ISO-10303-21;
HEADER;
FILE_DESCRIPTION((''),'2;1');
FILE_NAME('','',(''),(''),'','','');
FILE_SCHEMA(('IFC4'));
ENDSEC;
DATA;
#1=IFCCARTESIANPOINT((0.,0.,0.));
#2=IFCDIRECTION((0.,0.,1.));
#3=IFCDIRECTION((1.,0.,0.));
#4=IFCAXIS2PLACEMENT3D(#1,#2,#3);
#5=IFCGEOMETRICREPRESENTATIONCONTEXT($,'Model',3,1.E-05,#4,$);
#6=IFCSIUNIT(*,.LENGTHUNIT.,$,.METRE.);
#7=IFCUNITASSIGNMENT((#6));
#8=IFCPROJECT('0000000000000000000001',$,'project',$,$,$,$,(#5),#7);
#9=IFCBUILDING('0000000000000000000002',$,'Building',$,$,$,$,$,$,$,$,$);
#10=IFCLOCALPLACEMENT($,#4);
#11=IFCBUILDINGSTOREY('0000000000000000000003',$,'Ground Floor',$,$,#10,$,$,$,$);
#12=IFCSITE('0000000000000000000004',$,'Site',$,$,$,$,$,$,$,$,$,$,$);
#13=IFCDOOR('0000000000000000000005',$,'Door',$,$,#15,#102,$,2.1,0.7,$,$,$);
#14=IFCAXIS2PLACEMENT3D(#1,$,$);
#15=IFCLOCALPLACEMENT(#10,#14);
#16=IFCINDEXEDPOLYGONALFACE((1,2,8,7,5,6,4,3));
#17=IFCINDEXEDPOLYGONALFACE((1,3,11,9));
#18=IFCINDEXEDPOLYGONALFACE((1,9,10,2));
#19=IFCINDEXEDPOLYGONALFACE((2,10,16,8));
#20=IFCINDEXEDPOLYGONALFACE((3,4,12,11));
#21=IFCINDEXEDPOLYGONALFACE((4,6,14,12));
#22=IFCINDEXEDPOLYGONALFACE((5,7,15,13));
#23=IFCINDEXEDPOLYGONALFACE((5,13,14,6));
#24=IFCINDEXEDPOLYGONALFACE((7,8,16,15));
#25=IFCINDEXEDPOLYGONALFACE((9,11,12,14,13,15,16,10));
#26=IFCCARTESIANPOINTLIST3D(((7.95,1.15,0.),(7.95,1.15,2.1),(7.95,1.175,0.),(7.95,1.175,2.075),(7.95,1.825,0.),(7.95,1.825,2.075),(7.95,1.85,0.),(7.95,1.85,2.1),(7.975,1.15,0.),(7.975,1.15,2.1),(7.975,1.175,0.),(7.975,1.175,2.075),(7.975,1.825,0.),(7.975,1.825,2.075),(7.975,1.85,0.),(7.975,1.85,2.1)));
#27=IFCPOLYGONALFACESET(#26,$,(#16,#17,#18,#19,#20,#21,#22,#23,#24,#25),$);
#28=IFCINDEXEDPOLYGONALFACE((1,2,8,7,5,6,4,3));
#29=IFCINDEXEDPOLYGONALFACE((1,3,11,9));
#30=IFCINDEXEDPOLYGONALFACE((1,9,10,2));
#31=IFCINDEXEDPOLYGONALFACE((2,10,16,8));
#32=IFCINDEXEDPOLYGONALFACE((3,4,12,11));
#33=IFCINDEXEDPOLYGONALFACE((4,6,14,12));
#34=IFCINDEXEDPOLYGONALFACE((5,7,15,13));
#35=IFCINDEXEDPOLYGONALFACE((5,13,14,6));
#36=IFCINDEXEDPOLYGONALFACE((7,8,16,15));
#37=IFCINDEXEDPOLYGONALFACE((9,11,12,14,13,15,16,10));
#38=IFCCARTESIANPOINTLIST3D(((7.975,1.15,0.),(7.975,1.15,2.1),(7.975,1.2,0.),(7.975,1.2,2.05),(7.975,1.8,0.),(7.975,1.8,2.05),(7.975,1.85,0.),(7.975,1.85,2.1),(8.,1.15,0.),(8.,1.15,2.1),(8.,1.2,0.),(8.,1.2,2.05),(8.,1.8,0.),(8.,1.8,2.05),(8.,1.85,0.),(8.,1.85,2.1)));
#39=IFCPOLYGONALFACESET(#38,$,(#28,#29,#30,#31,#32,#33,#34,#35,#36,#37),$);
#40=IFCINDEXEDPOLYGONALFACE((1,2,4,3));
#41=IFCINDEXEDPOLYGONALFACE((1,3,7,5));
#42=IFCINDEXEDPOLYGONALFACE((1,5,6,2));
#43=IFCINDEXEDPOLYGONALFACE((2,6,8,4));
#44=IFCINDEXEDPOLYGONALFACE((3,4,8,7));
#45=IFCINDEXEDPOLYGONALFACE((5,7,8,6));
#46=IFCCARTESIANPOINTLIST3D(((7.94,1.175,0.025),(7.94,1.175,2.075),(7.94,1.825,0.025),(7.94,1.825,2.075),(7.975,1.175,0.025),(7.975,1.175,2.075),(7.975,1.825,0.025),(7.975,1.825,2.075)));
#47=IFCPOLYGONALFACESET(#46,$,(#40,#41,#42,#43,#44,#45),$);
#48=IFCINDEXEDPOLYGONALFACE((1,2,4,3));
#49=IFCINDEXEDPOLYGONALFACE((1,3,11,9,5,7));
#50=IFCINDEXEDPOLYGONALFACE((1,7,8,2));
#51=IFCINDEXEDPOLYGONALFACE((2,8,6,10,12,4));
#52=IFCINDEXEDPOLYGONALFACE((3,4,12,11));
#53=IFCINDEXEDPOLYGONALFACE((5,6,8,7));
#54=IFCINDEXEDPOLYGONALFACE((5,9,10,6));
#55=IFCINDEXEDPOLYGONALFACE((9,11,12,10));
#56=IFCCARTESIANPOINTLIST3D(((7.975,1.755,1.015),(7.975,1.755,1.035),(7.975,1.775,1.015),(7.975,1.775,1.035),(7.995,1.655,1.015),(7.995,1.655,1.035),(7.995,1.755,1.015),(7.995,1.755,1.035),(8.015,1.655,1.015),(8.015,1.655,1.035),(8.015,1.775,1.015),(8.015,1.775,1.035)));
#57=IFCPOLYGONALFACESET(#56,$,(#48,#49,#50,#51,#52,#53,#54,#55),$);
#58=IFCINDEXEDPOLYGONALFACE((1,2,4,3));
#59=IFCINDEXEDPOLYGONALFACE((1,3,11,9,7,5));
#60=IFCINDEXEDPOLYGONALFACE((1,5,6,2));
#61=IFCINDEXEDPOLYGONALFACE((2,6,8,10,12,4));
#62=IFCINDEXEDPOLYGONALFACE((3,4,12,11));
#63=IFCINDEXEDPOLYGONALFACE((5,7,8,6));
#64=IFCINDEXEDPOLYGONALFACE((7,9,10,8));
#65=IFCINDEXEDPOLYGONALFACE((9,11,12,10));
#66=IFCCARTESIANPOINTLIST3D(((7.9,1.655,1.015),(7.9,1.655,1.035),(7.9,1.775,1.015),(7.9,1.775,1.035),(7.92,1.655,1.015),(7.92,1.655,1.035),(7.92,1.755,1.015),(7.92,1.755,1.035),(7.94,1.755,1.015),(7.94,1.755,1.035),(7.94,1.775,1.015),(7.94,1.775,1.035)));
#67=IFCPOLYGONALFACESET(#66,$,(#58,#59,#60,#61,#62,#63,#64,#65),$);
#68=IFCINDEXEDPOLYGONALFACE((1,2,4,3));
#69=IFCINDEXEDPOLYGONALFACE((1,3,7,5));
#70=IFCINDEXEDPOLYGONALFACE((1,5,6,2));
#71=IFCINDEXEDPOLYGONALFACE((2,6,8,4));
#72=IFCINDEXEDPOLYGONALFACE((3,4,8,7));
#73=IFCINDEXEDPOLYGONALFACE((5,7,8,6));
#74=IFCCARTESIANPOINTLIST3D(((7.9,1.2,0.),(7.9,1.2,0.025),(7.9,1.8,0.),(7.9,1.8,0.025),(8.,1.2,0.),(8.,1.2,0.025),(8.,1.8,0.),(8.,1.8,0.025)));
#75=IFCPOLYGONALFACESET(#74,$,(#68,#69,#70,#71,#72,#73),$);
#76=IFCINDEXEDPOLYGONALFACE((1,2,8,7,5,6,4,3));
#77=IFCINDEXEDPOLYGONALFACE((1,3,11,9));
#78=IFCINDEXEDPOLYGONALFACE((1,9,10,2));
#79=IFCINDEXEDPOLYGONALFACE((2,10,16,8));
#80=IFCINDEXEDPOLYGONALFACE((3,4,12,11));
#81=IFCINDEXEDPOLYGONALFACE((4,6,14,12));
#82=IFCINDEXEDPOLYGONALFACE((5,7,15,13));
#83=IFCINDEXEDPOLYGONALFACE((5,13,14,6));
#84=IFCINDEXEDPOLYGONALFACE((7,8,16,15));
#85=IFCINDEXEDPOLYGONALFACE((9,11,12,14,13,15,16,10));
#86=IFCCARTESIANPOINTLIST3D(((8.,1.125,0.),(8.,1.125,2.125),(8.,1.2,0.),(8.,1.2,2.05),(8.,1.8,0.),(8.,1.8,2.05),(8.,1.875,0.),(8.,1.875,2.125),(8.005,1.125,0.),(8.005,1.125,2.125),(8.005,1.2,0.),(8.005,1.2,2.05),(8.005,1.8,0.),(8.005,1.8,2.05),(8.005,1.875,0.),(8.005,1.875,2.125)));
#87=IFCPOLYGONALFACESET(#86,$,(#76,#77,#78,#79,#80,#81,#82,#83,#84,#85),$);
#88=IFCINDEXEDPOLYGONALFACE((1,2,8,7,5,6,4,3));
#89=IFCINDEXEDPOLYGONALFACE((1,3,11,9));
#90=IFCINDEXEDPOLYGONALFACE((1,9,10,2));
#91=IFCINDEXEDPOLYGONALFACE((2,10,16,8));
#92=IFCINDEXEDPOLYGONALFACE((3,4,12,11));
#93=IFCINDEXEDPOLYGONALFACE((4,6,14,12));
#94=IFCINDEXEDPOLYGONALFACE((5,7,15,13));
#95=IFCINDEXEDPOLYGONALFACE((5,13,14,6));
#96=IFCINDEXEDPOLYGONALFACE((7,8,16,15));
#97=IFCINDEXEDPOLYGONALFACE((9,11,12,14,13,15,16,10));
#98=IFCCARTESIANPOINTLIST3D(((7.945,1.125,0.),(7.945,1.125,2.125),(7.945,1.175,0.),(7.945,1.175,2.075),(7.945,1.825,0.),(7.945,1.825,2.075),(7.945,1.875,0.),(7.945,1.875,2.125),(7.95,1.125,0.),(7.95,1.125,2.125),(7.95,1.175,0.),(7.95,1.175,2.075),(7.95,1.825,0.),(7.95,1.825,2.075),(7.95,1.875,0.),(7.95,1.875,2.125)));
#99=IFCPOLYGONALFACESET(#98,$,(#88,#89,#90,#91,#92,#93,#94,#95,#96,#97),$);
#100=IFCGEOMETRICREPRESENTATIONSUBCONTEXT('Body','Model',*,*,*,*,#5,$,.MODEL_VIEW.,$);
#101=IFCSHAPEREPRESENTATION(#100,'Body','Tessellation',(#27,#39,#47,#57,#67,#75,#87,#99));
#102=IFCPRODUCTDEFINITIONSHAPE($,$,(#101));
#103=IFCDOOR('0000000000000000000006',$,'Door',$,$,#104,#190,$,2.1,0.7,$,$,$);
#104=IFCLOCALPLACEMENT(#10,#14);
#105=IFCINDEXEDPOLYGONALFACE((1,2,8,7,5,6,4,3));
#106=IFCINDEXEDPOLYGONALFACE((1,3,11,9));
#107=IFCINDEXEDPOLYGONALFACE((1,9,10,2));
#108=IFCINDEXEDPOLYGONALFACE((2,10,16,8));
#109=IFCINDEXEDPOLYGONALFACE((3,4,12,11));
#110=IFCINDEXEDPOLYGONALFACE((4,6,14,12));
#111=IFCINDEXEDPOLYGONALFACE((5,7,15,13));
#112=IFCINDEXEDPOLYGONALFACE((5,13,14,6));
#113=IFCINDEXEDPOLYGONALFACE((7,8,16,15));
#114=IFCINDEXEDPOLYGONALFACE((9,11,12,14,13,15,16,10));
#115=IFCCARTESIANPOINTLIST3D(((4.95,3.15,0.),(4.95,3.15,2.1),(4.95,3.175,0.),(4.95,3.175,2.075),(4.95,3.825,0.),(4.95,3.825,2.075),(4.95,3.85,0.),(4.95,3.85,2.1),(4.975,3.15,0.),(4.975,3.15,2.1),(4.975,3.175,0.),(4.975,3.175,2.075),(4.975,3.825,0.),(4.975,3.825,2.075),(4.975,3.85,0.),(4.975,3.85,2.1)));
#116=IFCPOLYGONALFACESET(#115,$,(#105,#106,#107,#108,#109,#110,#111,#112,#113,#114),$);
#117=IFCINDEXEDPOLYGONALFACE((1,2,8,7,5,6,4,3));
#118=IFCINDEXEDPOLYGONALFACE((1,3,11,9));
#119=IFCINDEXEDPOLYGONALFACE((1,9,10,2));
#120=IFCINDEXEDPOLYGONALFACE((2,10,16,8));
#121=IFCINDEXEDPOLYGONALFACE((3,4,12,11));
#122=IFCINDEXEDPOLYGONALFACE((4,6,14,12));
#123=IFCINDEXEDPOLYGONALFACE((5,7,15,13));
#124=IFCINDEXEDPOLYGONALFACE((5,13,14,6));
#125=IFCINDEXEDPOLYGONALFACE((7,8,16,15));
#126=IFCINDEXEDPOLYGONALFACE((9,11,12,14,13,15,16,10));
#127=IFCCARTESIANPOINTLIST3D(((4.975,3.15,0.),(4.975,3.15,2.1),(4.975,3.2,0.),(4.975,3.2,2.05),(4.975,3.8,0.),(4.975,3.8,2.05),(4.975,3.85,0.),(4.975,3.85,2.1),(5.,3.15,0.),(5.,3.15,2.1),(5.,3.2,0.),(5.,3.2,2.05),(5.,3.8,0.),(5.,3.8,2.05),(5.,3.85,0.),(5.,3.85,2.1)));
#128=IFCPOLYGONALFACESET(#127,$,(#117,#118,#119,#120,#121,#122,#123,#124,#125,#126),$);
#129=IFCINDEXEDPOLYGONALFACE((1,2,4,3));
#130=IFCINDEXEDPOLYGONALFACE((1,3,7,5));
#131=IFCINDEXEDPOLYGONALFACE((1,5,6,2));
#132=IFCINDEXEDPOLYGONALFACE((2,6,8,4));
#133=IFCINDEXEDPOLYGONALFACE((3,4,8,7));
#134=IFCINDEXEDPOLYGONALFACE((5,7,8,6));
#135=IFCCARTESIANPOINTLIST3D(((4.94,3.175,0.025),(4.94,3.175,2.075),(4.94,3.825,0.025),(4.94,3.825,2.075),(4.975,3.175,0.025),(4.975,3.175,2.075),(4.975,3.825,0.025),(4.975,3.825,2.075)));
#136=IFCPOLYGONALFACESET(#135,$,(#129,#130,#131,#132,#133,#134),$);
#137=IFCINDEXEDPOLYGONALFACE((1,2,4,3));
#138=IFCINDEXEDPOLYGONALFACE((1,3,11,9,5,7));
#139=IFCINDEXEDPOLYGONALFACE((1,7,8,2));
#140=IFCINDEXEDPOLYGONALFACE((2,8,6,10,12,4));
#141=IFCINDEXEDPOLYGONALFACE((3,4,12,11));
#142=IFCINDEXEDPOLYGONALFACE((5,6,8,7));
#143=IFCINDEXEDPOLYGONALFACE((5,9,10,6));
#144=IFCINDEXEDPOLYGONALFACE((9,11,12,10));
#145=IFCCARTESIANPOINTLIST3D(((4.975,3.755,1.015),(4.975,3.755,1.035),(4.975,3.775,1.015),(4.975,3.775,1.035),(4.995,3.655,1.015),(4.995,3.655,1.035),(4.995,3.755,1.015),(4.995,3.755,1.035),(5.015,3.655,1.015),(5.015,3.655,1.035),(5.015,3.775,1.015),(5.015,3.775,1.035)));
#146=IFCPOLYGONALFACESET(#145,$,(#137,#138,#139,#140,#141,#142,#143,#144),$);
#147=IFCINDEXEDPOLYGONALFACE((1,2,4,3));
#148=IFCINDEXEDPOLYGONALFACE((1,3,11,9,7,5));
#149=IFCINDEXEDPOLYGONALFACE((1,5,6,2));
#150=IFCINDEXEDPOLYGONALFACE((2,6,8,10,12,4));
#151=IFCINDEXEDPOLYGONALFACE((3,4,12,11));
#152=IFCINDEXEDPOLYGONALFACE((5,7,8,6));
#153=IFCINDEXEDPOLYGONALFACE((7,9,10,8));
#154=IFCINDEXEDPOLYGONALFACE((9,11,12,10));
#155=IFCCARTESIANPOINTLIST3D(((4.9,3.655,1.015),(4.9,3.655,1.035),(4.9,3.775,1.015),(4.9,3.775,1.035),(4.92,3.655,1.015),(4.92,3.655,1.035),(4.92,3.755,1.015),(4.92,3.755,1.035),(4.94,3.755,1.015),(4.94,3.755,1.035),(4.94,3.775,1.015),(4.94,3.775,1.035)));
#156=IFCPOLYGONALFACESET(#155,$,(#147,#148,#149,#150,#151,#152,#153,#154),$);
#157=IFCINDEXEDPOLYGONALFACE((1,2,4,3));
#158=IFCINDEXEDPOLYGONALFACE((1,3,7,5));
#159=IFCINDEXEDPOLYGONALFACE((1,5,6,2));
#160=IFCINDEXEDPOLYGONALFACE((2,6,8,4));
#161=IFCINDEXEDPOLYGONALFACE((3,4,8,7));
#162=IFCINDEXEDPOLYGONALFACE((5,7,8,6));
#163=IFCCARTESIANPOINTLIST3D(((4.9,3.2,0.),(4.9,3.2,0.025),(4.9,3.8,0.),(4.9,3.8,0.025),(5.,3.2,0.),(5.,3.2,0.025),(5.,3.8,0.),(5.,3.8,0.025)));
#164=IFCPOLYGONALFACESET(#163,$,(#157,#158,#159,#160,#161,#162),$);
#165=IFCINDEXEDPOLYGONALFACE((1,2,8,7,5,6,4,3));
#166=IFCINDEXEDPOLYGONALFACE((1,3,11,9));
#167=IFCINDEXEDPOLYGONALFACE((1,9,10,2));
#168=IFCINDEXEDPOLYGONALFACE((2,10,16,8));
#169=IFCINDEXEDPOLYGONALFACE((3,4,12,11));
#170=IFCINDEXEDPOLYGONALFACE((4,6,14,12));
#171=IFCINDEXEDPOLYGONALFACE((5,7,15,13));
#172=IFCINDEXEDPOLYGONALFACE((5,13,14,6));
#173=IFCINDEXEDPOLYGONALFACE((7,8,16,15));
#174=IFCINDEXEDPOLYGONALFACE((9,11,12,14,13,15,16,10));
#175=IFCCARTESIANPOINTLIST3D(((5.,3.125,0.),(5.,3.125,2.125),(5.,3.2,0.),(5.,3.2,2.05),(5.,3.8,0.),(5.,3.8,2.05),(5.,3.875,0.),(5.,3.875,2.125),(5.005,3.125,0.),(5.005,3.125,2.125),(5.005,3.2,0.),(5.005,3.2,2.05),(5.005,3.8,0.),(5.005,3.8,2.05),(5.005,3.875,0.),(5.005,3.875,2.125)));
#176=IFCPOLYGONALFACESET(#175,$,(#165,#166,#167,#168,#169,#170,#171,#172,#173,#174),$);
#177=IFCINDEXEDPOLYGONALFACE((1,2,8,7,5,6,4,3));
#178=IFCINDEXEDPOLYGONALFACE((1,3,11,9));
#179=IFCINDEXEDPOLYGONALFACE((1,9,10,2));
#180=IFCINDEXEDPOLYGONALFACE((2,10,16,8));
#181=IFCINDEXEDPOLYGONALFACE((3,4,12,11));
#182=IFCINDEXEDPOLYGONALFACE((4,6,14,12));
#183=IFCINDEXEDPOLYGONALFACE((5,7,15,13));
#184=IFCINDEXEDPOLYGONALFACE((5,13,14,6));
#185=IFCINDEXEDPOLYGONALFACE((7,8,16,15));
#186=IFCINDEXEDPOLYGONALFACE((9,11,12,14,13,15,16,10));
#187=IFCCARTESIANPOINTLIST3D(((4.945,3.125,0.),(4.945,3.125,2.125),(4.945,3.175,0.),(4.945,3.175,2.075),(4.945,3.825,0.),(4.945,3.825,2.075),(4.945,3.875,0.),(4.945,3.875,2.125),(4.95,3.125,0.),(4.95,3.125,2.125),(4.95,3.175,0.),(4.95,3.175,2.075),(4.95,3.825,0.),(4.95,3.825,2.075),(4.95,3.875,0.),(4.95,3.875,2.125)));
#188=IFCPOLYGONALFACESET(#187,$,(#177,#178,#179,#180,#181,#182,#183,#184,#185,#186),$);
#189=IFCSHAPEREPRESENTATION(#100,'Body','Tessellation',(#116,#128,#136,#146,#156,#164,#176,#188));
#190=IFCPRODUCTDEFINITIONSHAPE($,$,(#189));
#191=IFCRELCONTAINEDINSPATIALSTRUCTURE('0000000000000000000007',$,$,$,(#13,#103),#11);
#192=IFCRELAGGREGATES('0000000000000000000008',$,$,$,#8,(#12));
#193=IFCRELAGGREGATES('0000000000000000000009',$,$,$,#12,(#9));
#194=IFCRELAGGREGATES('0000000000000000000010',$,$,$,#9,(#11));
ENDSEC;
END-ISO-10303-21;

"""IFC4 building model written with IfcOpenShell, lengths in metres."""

from ifc_helpers import new_model, si_unit, frame, origin_with_axes, place, context, subcontext, project, spatial, line, indexed_curve, outline, extrude, element, save


model = new_model("IFC4")

# Units and contexts
model_context = context("Model", 3, precision=1e-05, world=origin_with_axes())
body_context = subcontext(model_context, "Body", "Model", "MODEL_VIEW")
ifc_project = project(units=[si_unit("LENGTHUNIT", "METRE")], contexts=[model_context])

# Site, building, storey
site = spatial("IfcSite", under=ifc_project, Name="Site")
building = spatial("IfcBuilding", under=site, Name="Building")
storey_placement = place(None, origin_with_axes())
storey = spatial("IfcBuildingStorey", under=building, at=storey_placement, Name="Ground Floor")

# Doors
door_1_placement = place(storey_placement, frame((8.0, 1.15, 0.0), z_axis=(0.0, 0.0, 1.0), x_axis=(0.0, 1.0, 0.0)))
element("IfcDoor", 1, at=door_1_placement, inside=storey, Name="Door", OverallHeight=2.1, OverallWidth=0.7, context=body_context, shape_type="SweptSolid", body=[
    extrude(outline(indexed_curve([(0.0, 0.0), (0.0, 2.1), (0.7, 2.1), (0.7, 0.0), (0.675, 0.0), (0.675, 2.075), (0.025, 2.075), (0.025, 0.0)], segments=[line(1, 2, 3, 4, 5, 6, 7, 8, 1)])), frame((0.0, 0.025, 0.0), z_axis=(0.0, -1.0, 0.0), x_axis=(1.0, 0.0, 0.0)), (0.0, 0.0, -1.0), 0.025),
    extrude(outline(indexed_curve([(0.0, 0.0), (0.0, 2.1), (0.7, 2.1), (0.7, 0.0), (0.65, 0.0), (0.65, 2.05), (0.05, 2.05), (0.05, 0.0)], segments=[line(1, 2, 3, 4, 5, 6, 7, 8, 1)])), frame((0.0, 0.0, 0.0), z_axis=(0.0, -1.0, 0.0), x_axis=(1.0, 0.0, 0.0)), (0.0, 0.0, -1.0), 0.025),
    extrude(outline(indexed_curve([(0.0, 0.0), (0.65, 0.0), (0.65, 0.035), (0.0, 0.035)], segments=[line(1, 2, 3, 4, 1)])), frame((0.025, 0.025, 0.025), z_axis=(0.0, 0.0, 1.0), x_axis=(1.0, 0.0, 0.0)), (0.0, 0.0, 1.0), 2.05),
    extrude(outline(indexed_curve([(0.0, 0.0), (0.0, -0.04), (-0.12, -0.04), (-0.12, -0.02), (-0.02, -0.02), (-0.02, 0.0)], segments=[line(1, 2, 3, 4, 5, 6, 1)])), frame((0.625, 0.025, 1.015), z_axis=(0.0, 0.0, 1.0), x_axis=(1.0, 0.0, 0.0)), (0.0, 0.0, 1.0), 0.02),
    extrude(outline(indexed_curve([(0.0, 0.0), (0.0, 0.04), (-0.12, 0.04), (-0.12, 0.02), (-0.02, 0.02), (-0.02, 0.0)], segments=[line(1, 2, 3, 4, 5, 6, 1)])), frame((0.625, 0.06, 1.015), z_axis=(0.0, 0.0, 1.0), x_axis=(1.0, 0.0, 0.0)), (0.0, 0.0, 1.0), 0.02),
    extrude(outline(indexed_curve([(0.0, 0.0), (0.6, 0.0), (0.6, 0.1), (0.0, 0.1)], segments=[line(1, 2, 3, 4, 1)])), frame((0.05, 0.0, 0.0), z_axis=(0.0, 0.0, 1.0), x_axis=(1.0, 0.0, 0.0)), (0.0, 0.0, 1.0), 0.025),
    extrude(outline(indexed_curve([(0.0, 0.0), (0.0, 2.125), (0.75, 2.125), (0.75, 0.0), (0.675, 0.0), (0.675, 2.05), (0.075, 2.05), (0.075, 0.0)], segments=[line(1, 2, 3, 4, 5, 6, 7, 8, 1)])), frame((-0.025, -0.005, 0.0), z_axis=(0.0, -1.0, 0.0), x_axis=(1.0, 0.0, 0.0)), (0.0, 0.0, -1.0), 0.005),
    extrude(outline(indexed_curve([(0.0, 0.0), (0.0, 2.125), (0.75, 2.125), (0.75, 0.0), (0.7, 0.0), (0.7, 2.075), (0.05, 2.075), (0.05, 0.0)], segments=[line(1, 2, 3, 4, 5, 6, 7, 8, 1)])), frame((-0.025, 0.05, 0.0), z_axis=(0.0, -1.0, 0.0), x_axis=(1.0, 0.0, 0.0)), (0.0, 0.0, -1.0), 0.005),
])
door_2_placement = place(storey_placement, frame((5.0, 3.15, 0.0), z_axis=(0.0, 0.0, 1.0), x_axis=(0.0, 1.0, 0.0)))
element("IfcDoor", 2, at=door_2_placement, inside=storey, Name="Door", OverallHeight=2.1, OverallWidth=0.7, context=body_context, shape_type="SweptSolid", body=[
    extrude(outline(indexed_curve([(0.0, 0.0), (0.0, 2.1), (0.7, 2.1), (0.7, 0.0), (0.675, 0.0), (0.675, 2.075), (0.025, 2.075), (0.025, 0.0)], segments=[line(1, 2, 3, 4, 5, 6, 7, 8, 1)])), frame((0.0, 0.025, 0.0), z_axis=(0.0, -1.0, 0.0), x_axis=(1.0, 0.0, 0.0)), (0.0, 0.0, -1.0), 0.025),
    extrude(outline(indexed_curve([(0.0, 0.0), (0.0, 2.1), (0.7, 2.1), (0.7, 0.0), (0.65, 0.0), (0.65, 2.05), (0.05, 2.05), (0.05, 0.0)], segments=[line(1, 2, 3, 4, 5, 6, 7, 8, 1)])), frame((0.0, 0.0, 0.0), z_axis=(0.0, -1.0, 0.0), x_axis=(1.0, 0.0, 0.0)), (0.0, 0.0, -1.0), 0.025),
    extrude(outline(indexed_curve([(0.0, 0.0), (0.65, 0.0), (0.65, 0.035), (0.0, 0.035)], segments=[line(1, 2, 3, 4, 1)])), frame((0.025, 0.025, 0.025), z_axis=(0.0, 0.0, 1.0), x_axis=(1.0, 0.0, 0.0)), (0.0, 0.0, 1.0), 2.05),
    extrude(outline(indexed_curve([(0.0, 0.0), (0.0, -0.04), (-0.12, -0.04), (-0.12, -0.02), (-0.02, -0.02), (-0.02, 0.0)], segments=[line(1, 2, 3, 4, 5, 6, 1)])), frame((0.625, 0.025, 1.015), z_axis=(0.0, 0.0, 1.0), x_axis=(1.0, 0.0, 0.0)), (0.0, 0.0, 1.0), 0.02),
    extrude(outline(indexed_curve([(0.0, 0.0), (0.0, 0.04), (-0.12, 0.04), (-0.12, 0.02), (-0.02, 0.02), (-0.02, 0.0)], segments=[line(1, 2, 3, 4, 5, 6, 1)])), frame((0.625, 0.06, 1.015), z_axis=(0.0, 0.0, 1.0), x_axis=(1.0, 0.0, 0.0)), (0.0, 0.0, 1.0), 0.02),
    extrude(outline(indexed_curve([(0.0, 0.0), (0.6, 0.0), (0.6, 0.1), (0.0, 0.1)], segments=[line(1, 2, 3, 4, 1)])), frame((0.05, 0.0, 0.0), z_axis=(0.0, 0.0, 1.0), x_axis=(1.0, 0.0, 0.0)), (0.0, 0.0, 1.0), 0.025),
    extrude(outline(indexed_curve([(0.0, 0.0), (0.0, 2.125), (0.75, 2.125), (0.75, 0.0), (0.675, 0.0), (0.675, 2.05), (0.075, 2.05), (0.075, 0.0)], segments=[line(1, 2, 3, 4, 5, 6, 7, 8, 1)])), frame((-0.025, -0.005, 0.0), z_axis=(0.0, -1.0, 0.0), x_axis=(1.0, 0.0, 0.0)), (0.0, 0.0, -1.0), 0.005),
    extrude(outline(indexed_curve([(0.0, 0.0), (0.0, 2.125), (0.75, 2.125), (0.75, 0.0), (0.7, 0.0), (0.7, 2.075), (0.05, 2.075), (0.05, 0.0)], segments=[line(1, 2, 3, 4, 5, 6, 7, 8, 1)])), frame((-0.025, 0.05, 0.0), z_axis=(0.0, -1.0, 0.0), x_axis=(1.0, 0.0, 0.0)), (0.0, 0.0, -1.0), 0.005),
])

save(model, "model.ifc")
